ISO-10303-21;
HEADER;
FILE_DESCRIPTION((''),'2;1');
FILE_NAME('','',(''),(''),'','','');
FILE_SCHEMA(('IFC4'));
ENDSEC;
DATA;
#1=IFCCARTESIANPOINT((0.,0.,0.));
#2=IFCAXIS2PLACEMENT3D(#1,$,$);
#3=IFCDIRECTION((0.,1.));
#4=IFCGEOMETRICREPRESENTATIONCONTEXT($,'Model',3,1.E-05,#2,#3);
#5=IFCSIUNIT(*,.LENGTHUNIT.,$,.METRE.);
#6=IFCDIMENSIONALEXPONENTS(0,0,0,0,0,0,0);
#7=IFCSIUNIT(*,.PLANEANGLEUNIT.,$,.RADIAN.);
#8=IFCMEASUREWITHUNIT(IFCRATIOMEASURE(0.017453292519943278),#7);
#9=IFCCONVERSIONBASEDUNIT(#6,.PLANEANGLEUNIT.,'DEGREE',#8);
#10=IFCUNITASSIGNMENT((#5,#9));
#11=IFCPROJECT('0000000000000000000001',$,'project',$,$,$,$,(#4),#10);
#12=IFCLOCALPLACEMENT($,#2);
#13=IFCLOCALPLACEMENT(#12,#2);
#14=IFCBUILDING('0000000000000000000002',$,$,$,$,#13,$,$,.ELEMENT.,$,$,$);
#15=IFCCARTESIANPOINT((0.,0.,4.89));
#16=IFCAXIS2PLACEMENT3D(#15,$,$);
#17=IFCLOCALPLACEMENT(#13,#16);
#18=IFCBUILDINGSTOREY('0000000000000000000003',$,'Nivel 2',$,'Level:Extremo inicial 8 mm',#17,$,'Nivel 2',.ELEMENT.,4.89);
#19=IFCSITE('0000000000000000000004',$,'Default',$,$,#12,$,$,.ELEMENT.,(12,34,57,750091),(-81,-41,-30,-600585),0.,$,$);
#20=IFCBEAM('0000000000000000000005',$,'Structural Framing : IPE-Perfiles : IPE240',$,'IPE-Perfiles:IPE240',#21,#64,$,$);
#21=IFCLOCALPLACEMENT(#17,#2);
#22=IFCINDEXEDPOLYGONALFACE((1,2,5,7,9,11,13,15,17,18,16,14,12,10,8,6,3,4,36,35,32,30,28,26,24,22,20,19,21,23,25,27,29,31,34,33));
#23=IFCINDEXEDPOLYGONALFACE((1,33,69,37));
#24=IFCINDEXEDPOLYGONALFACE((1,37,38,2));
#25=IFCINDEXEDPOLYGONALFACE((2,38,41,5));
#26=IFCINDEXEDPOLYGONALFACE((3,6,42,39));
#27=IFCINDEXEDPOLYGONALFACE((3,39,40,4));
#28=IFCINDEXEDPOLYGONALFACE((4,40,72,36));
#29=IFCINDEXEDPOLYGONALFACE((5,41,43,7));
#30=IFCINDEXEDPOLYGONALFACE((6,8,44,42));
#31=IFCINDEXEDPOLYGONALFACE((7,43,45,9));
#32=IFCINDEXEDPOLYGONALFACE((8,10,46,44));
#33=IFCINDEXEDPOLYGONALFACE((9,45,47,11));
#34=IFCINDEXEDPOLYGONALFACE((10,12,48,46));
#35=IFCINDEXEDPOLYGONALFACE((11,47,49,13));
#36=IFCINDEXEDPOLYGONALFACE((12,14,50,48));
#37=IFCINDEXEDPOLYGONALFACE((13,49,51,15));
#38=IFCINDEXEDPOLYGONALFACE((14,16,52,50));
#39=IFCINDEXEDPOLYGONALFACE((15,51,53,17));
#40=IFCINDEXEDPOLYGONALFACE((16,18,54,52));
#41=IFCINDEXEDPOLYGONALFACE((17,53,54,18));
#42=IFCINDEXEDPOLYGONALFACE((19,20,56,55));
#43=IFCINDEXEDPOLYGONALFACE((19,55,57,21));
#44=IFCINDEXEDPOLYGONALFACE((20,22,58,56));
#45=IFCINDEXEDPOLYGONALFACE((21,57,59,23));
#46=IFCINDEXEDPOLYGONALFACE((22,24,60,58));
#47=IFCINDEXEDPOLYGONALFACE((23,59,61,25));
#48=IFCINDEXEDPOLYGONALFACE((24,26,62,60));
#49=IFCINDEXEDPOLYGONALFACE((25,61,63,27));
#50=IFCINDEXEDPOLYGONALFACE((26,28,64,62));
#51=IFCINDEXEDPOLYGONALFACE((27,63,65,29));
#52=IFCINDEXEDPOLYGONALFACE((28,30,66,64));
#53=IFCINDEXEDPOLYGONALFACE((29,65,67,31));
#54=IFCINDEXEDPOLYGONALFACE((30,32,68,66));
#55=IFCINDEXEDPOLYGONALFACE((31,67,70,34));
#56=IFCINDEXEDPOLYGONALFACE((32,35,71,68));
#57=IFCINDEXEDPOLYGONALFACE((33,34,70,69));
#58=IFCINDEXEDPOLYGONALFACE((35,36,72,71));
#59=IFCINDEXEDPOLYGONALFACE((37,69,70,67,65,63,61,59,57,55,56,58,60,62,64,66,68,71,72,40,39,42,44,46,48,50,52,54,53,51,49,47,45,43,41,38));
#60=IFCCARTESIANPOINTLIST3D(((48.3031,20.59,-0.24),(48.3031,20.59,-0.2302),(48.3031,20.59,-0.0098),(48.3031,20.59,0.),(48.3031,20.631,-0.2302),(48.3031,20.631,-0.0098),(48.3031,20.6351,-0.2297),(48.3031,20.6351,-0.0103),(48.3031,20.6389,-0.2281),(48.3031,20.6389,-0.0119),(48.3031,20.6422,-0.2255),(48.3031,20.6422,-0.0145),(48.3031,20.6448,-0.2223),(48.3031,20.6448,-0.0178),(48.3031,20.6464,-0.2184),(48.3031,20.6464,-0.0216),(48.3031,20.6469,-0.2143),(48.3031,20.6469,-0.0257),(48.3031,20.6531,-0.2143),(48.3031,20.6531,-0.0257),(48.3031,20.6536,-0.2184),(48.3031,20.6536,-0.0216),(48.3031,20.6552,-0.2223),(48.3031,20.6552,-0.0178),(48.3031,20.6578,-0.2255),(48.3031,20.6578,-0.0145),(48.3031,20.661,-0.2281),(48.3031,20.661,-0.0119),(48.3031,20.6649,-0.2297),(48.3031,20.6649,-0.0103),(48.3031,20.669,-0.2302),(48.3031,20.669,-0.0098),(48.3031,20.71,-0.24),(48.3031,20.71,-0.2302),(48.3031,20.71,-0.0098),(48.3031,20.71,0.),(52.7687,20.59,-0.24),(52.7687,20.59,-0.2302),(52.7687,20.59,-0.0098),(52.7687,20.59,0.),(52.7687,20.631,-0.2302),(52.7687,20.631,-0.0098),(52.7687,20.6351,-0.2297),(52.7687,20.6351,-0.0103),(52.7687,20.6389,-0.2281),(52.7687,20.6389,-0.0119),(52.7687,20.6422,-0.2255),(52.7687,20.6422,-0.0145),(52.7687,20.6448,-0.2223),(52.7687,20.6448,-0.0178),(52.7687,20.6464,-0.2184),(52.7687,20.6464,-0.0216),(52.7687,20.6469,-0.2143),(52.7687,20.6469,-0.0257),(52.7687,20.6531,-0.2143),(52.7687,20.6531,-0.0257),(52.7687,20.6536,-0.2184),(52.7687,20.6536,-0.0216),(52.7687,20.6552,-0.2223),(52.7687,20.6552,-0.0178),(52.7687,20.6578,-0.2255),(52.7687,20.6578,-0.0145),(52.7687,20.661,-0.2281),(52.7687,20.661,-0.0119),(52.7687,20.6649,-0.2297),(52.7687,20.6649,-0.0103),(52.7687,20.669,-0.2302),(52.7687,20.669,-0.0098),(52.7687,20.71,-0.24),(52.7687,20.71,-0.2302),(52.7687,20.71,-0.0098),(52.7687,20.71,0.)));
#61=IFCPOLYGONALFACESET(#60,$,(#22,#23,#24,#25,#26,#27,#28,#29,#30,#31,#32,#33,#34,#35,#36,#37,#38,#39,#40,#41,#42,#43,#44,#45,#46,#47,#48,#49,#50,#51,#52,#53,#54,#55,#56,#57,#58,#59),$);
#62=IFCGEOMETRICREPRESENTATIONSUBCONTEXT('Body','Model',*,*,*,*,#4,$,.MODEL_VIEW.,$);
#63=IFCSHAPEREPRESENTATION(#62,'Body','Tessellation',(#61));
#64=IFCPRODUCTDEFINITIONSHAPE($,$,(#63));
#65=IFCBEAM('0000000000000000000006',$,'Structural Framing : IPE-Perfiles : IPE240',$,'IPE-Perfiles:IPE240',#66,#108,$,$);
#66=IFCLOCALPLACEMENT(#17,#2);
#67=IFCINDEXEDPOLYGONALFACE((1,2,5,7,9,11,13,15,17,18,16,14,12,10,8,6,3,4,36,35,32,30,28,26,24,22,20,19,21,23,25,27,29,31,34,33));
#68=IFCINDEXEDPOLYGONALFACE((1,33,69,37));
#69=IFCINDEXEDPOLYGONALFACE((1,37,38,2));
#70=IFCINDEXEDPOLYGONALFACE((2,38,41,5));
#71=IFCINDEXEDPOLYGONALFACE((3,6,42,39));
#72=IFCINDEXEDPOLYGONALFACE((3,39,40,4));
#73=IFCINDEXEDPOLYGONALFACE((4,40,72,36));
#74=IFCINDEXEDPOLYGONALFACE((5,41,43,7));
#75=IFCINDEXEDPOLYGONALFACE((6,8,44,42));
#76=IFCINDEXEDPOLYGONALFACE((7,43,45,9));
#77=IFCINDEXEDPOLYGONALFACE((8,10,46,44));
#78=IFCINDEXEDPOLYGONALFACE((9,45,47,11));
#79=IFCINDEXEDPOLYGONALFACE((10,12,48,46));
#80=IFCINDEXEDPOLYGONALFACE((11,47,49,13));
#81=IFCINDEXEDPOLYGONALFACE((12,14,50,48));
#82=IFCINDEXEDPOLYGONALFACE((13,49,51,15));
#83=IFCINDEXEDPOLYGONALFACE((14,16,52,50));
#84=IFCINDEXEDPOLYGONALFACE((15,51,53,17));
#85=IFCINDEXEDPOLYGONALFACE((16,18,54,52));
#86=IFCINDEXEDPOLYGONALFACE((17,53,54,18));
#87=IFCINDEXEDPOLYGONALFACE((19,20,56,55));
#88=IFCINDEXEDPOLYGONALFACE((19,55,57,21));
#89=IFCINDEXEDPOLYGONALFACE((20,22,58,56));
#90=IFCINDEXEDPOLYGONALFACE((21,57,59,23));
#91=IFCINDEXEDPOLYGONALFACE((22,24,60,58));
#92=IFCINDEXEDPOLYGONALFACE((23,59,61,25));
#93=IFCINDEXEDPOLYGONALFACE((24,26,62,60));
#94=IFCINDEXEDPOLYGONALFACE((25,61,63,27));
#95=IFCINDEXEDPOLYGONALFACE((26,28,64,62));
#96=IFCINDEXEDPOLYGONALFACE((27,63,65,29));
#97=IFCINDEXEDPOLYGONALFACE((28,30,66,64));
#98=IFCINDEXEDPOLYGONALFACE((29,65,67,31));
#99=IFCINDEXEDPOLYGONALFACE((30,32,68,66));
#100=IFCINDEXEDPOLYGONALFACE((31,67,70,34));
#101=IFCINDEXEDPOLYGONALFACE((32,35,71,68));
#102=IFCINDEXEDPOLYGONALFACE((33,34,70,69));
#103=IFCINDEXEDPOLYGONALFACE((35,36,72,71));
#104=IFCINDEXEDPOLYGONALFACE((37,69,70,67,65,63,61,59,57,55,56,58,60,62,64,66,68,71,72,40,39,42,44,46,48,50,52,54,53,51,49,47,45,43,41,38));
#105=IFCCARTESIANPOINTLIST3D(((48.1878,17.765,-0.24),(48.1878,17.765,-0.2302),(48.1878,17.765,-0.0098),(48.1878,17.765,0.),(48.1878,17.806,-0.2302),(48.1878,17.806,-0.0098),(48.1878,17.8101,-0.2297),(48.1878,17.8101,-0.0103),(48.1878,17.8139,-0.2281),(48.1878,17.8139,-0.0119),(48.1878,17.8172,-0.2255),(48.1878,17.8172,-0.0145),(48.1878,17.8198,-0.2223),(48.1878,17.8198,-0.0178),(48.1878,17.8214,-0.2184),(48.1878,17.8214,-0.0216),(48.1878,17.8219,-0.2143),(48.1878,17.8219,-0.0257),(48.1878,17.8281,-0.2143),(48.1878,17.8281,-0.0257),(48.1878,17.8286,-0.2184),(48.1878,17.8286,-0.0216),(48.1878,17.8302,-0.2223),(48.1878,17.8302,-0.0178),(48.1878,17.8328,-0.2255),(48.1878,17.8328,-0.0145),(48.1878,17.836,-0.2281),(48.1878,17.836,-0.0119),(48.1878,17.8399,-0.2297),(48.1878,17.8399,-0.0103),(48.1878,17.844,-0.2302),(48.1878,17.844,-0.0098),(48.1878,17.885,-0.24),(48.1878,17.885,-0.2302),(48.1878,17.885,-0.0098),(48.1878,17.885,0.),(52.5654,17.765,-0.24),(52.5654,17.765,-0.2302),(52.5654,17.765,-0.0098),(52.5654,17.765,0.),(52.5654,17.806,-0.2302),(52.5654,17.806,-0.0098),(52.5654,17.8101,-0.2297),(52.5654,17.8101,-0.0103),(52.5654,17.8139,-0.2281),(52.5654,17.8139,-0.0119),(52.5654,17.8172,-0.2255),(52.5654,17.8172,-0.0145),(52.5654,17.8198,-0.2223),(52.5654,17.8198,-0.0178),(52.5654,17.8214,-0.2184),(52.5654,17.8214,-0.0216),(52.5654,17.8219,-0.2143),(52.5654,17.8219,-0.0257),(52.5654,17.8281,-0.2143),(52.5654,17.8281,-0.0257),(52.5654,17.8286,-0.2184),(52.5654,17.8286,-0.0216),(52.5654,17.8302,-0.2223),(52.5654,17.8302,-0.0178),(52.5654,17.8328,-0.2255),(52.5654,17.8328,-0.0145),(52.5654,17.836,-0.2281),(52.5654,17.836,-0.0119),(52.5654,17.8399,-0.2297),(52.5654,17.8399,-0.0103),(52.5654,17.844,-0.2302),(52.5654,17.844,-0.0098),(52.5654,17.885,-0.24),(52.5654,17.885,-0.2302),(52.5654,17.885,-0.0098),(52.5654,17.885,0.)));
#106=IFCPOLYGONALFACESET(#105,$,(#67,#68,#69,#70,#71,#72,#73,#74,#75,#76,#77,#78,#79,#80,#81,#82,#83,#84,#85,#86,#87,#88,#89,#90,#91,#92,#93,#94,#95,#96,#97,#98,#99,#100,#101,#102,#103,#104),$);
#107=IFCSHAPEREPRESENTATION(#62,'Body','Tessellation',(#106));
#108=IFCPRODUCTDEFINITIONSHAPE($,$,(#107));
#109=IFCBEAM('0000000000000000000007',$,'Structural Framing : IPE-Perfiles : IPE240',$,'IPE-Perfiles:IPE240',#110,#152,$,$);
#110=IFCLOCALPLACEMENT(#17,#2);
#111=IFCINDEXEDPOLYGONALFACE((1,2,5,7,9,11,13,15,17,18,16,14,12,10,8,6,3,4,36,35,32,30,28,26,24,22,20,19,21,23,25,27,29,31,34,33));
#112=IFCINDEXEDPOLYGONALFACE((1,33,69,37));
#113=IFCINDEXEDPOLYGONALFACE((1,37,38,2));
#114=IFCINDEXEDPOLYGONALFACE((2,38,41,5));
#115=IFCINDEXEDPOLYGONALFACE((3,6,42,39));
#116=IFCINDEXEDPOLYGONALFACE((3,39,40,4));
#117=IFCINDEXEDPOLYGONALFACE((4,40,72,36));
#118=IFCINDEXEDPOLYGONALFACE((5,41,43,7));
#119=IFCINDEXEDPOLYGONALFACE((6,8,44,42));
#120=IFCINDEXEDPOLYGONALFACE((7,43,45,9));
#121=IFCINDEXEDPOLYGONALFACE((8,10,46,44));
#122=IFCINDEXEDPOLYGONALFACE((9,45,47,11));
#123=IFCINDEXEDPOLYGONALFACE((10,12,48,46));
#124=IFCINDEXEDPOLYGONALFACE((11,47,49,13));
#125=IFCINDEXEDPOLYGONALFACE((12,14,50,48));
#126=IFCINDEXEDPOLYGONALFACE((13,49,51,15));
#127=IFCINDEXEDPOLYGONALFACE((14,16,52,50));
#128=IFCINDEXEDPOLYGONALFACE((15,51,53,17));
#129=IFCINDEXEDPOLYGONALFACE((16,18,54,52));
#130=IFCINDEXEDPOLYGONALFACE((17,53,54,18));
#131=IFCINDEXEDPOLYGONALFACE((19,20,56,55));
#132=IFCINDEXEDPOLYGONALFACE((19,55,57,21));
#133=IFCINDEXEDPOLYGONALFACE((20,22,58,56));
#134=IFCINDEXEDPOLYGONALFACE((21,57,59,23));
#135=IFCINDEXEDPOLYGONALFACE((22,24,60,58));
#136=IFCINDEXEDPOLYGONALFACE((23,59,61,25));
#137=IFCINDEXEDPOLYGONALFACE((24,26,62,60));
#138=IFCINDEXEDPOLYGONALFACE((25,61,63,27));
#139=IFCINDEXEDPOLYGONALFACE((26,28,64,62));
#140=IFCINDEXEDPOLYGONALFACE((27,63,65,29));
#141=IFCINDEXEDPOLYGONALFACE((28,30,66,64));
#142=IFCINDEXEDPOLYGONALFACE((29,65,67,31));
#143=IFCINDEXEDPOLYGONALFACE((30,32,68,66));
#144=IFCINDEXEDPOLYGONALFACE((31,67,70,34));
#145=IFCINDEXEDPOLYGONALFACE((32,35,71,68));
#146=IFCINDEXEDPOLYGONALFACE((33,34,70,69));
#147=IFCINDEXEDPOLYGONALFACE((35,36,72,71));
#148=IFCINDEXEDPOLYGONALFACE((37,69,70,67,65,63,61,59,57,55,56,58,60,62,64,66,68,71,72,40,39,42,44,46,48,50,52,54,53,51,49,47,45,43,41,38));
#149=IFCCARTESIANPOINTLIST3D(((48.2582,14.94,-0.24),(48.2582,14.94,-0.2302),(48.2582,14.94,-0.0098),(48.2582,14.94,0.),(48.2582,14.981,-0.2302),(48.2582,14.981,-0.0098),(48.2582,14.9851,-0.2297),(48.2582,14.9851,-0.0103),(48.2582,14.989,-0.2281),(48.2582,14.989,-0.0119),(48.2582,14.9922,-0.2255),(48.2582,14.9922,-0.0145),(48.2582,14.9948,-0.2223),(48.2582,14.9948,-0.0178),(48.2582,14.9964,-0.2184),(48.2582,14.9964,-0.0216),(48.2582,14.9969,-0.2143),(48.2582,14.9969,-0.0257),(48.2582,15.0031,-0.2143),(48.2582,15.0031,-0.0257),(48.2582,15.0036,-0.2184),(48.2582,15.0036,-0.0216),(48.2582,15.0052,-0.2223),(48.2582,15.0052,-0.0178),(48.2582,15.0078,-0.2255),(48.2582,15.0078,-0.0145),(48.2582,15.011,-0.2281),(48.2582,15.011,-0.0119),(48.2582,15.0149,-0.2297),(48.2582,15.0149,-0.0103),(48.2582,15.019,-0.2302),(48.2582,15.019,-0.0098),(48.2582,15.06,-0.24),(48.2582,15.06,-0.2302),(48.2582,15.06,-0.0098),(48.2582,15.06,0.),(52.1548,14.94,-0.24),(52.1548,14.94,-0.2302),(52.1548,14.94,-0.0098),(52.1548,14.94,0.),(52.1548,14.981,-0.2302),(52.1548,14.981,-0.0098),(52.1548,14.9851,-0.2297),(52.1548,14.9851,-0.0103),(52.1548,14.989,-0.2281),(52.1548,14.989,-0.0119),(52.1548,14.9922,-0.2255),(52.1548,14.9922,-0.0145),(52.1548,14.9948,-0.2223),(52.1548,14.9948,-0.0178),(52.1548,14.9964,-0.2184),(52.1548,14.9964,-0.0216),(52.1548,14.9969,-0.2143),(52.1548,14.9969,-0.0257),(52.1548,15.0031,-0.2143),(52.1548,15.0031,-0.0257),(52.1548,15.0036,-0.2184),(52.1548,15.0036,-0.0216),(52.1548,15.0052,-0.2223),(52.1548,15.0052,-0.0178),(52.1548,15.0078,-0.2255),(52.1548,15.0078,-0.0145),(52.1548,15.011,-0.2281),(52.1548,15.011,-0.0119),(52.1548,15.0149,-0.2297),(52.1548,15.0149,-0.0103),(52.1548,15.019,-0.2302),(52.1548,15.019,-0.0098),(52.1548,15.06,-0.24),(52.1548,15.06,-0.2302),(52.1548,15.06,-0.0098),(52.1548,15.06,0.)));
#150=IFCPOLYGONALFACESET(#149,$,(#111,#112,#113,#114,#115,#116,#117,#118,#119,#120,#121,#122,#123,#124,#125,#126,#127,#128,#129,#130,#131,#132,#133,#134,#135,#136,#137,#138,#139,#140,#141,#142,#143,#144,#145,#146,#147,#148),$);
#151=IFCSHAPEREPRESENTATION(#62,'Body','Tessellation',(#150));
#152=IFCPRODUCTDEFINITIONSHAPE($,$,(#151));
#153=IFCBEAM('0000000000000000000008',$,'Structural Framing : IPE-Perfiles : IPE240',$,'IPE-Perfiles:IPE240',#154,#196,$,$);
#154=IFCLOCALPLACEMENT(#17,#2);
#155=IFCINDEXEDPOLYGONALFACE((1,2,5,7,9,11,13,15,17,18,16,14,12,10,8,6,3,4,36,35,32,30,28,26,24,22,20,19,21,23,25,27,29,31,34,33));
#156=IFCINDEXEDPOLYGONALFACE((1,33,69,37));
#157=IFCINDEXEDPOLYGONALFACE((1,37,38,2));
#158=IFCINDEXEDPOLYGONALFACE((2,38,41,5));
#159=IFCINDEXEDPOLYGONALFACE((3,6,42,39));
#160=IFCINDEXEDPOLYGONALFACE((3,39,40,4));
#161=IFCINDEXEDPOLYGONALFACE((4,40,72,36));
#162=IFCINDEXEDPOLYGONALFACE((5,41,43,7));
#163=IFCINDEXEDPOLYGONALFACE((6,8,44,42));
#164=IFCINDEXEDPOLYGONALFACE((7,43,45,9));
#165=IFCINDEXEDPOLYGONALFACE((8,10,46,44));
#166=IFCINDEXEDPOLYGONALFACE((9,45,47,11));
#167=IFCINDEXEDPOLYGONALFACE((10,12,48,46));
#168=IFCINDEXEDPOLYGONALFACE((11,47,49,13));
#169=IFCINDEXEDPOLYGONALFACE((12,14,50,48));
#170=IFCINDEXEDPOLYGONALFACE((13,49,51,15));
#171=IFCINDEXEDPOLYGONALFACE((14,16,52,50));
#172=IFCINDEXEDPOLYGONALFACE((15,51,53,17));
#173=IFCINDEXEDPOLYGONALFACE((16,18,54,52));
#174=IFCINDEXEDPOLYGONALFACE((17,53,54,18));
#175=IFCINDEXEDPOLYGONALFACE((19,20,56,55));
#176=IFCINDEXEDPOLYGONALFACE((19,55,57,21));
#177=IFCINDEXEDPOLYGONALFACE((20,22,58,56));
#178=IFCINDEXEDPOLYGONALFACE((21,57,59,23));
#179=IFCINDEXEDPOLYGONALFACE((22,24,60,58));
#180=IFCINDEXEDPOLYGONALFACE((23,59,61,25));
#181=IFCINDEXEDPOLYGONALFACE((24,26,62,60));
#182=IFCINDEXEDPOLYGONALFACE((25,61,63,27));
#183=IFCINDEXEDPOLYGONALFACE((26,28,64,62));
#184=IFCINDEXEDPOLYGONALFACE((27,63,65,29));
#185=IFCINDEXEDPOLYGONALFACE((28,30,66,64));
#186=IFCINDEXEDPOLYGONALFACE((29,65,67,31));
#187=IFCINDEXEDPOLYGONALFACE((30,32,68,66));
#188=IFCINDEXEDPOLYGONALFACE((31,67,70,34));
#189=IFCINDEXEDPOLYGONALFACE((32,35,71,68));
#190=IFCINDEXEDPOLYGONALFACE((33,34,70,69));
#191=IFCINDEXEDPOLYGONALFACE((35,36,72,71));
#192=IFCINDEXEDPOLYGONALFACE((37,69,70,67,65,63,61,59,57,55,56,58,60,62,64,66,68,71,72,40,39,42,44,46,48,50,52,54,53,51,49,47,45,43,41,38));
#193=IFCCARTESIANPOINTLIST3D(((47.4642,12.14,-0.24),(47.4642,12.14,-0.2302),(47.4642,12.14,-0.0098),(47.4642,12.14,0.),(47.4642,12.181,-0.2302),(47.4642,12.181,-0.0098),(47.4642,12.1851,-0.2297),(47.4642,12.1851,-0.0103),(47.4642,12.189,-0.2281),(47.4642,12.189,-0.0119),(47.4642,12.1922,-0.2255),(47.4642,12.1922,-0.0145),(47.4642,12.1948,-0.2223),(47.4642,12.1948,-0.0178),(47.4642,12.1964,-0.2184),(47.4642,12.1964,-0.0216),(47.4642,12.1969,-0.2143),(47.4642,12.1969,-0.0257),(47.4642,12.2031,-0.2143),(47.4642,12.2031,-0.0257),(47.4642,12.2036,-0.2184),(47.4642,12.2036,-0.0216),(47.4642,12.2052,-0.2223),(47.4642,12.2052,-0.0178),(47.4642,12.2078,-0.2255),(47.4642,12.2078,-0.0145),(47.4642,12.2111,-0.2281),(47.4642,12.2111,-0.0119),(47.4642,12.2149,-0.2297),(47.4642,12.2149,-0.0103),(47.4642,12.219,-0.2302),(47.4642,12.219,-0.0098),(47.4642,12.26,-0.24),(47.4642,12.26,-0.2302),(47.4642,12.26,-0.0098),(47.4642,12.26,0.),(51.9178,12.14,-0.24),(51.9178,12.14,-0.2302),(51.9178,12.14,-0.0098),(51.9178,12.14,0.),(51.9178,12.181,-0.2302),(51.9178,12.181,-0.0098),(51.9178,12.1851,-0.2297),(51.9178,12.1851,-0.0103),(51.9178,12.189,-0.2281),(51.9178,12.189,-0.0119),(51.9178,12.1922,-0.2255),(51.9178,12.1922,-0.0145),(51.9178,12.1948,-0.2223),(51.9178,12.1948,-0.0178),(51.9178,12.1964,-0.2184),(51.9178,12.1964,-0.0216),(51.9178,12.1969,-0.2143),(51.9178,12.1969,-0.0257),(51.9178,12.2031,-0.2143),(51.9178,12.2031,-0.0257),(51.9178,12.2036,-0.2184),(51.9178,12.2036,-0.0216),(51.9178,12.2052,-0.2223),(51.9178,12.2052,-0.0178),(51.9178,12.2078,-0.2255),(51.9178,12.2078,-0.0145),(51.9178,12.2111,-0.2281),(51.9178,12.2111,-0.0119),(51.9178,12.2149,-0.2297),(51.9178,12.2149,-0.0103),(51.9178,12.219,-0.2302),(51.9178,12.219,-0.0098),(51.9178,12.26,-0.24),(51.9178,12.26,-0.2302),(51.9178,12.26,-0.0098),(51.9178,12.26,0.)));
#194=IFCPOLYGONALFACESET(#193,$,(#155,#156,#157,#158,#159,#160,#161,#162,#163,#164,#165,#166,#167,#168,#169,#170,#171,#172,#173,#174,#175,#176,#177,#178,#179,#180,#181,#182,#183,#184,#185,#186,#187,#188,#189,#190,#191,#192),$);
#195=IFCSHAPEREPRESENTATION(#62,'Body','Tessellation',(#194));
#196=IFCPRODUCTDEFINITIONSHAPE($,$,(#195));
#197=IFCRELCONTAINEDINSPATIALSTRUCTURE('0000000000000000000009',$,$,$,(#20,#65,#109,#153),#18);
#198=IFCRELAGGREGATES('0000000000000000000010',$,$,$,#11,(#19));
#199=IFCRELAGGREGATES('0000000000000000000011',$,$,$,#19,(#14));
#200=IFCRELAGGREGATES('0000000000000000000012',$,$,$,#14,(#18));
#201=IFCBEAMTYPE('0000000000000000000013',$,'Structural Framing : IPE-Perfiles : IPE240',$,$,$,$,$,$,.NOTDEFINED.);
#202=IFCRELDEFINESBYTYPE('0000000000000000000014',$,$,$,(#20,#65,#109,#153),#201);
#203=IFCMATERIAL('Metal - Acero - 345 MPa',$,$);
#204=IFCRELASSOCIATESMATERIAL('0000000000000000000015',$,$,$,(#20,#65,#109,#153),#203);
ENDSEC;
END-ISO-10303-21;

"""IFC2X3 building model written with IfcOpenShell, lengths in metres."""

from ifc_helpers import new_model, entity, si_unit, converted_unit, direction, frame, frame_2d, origin, place, context, subcontext, project, spatial, i_section, extrude, material, type_object, element, save


model = new_model("IFC2X3")

# Units and contexts
model_context = context("Model", 3, precision=1e-05, world=origin(), true_north=direction((0.0, 1.0)))
body_context = subcontext(model_context, "Body", "Model", "MODEL_VIEW")
ifc_project = project(units=[si_unit("LENGTHUNIT", "METRE"), converted_unit("PLANEANGLEUNIT", "DEGREE", entity("IfcRatioMeasure", 0.017453292519943278), si_unit("PLANEANGLEUNIT", "RADIAN"), dimensions=[0, 0, 0, 0, 0, 0, 0])], contexts=[model_context])

# Site, building, storey
site_placement = place(None, origin())
site = spatial("IfcSite", under=ifc_project, at=site_placement, Name="Default", CompositionType="ELEMENT", RefLatitude=(12, 34, 57, 750091), RefLongitude=(-81, -41, -30, -600585), RefElevation=0.0)
building_placement = place(site_placement, origin())
building = spatial("IfcBuilding", under=site, at=building_placement, CompositionType="ELEMENT")
storey_placement = place(building_placement, frame((0.0, 0.0, 4.89)))
storey = spatial("IfcBuildingStorey", under=building, at=storey_placement, Name="Nivel 2", ObjectType="Level:Extremo inicial 8 mm", LongName="Nivel 2", CompositionType="ELEMENT", Elevation=4.89)

# Shared definitions
ifc_material_1 = material(Name="Metal - Acero - 345 MPa")

# Beams
beam_type_1 = type_object("IfcBeamType", Name="Structural Framing : IPE-Perfiles : IPE240", PredefinedType="NOTDEFINED")
beam_1_placement = place(storey_placement, frame((48.29, 20.65, 0.0)))
element("IfcBeam", 1, at=beam_1_placement, inside=storey, type_object=beam_type_1, material=ifc_material_1, Name="Structural Framing : IPE-Perfiles : IPE240", ObjectType="IPE-Perfiles:IPE240", context=body_context, shape_type="SweptSolid", body=[
    extrude(i_section(OverallWidth=0.12, OverallDepth=0.24, WebThickness=0.0062, FlangeThickness=0.0098, FilletRadius=0.0159, at=frame_2d((0.0, 0.0), x_axis=(0.0, 1.0))), frame((0.0131, 0.0, -0.12), z_axis=(1.0, 0.0, 0.0), x_axis=(0.0, 0.0, -1.0)), (0.0, 0.0, 1.0), 4.4656),
])
beam_2_placement = place(storey_placement, frame((48.095, 17.825, 0.0)))
element("IfcBeam", 2, at=beam_2_placement, inside=storey, type_object=beam_type_1, material=ifc_material_1, Name="Structural Framing : IPE-Perfiles : IPE240", ObjectType="IPE-Perfiles:IPE240", context=body_context, shape_type="SweptSolid", body=[
    extrude(i_section(OverallWidth=0.12, OverallDepth=0.24, WebThickness=0.0062, FlangeThickness=0.0098, FilletRadius=0.0159, at=frame_2d((0.0, 0.0), x_axis=(0.0, 1.0))), frame((0.0928, 0.0, -0.12), z_axis=(1.0, 0.0, 0.0), x_axis=(0.0, 0.0, -1.0)), (0.0, 0.0, 1.0), 4.3776),
])
beam_3_placement = place(storey_placement, frame((48.1005, 15.0, 0.0)))
element("IfcBeam", 3, at=beam_3_placement, inside=storey, type_object=beam_type_1, material=ifc_material_1, Name="Structural Framing : IPE-Perfiles : IPE240", ObjectType="IPE-Perfiles:IPE240", context=body_context, shape_type="SweptSolid", body=[
    extrude(i_section(OverallWidth=0.12, OverallDepth=0.24, WebThickness=0.0062, FlangeThickness=0.0098, FilletRadius=0.0159, at=frame_2d((0.0, 0.0), x_axis=(0.0, 1.0))), frame((0.1577, 0.0, -0.12), z_axis=(1.0, 0.0, 0.0), x_axis=(0.0, 0.0, -1.0)), (0.0, 0.0, 1.0), 3.8966),
])
beam_4_placement = place(storey_placement, frame((47.3504, 12.2, 0.0)))
element("IfcBeam", 4, at=beam_4_placement, inside=storey, type_object=beam_type_1, material=ifc_material_1, Name="Structural Framing : IPE-Perfiles : IPE240", ObjectType="IPE-Perfiles:IPE240", context=body_context, shape_type="SweptSolid", body=[
    extrude(i_section(OverallWidth=0.12, OverallDepth=0.24, WebThickness=0.0062, FlangeThickness=0.0098, FilletRadius=0.0159, at=frame_2d((0.0, 0.0), x_axis=(0.0, 1.0))), frame((0.1139, 0.0, -0.12), z_axis=(1.0, 0.0, 0.0), x_axis=(0.0, 0.0, -1.0)), (0.0, 0.0, 1.0), 4.4536),
])

save(model, "model.ifc")
